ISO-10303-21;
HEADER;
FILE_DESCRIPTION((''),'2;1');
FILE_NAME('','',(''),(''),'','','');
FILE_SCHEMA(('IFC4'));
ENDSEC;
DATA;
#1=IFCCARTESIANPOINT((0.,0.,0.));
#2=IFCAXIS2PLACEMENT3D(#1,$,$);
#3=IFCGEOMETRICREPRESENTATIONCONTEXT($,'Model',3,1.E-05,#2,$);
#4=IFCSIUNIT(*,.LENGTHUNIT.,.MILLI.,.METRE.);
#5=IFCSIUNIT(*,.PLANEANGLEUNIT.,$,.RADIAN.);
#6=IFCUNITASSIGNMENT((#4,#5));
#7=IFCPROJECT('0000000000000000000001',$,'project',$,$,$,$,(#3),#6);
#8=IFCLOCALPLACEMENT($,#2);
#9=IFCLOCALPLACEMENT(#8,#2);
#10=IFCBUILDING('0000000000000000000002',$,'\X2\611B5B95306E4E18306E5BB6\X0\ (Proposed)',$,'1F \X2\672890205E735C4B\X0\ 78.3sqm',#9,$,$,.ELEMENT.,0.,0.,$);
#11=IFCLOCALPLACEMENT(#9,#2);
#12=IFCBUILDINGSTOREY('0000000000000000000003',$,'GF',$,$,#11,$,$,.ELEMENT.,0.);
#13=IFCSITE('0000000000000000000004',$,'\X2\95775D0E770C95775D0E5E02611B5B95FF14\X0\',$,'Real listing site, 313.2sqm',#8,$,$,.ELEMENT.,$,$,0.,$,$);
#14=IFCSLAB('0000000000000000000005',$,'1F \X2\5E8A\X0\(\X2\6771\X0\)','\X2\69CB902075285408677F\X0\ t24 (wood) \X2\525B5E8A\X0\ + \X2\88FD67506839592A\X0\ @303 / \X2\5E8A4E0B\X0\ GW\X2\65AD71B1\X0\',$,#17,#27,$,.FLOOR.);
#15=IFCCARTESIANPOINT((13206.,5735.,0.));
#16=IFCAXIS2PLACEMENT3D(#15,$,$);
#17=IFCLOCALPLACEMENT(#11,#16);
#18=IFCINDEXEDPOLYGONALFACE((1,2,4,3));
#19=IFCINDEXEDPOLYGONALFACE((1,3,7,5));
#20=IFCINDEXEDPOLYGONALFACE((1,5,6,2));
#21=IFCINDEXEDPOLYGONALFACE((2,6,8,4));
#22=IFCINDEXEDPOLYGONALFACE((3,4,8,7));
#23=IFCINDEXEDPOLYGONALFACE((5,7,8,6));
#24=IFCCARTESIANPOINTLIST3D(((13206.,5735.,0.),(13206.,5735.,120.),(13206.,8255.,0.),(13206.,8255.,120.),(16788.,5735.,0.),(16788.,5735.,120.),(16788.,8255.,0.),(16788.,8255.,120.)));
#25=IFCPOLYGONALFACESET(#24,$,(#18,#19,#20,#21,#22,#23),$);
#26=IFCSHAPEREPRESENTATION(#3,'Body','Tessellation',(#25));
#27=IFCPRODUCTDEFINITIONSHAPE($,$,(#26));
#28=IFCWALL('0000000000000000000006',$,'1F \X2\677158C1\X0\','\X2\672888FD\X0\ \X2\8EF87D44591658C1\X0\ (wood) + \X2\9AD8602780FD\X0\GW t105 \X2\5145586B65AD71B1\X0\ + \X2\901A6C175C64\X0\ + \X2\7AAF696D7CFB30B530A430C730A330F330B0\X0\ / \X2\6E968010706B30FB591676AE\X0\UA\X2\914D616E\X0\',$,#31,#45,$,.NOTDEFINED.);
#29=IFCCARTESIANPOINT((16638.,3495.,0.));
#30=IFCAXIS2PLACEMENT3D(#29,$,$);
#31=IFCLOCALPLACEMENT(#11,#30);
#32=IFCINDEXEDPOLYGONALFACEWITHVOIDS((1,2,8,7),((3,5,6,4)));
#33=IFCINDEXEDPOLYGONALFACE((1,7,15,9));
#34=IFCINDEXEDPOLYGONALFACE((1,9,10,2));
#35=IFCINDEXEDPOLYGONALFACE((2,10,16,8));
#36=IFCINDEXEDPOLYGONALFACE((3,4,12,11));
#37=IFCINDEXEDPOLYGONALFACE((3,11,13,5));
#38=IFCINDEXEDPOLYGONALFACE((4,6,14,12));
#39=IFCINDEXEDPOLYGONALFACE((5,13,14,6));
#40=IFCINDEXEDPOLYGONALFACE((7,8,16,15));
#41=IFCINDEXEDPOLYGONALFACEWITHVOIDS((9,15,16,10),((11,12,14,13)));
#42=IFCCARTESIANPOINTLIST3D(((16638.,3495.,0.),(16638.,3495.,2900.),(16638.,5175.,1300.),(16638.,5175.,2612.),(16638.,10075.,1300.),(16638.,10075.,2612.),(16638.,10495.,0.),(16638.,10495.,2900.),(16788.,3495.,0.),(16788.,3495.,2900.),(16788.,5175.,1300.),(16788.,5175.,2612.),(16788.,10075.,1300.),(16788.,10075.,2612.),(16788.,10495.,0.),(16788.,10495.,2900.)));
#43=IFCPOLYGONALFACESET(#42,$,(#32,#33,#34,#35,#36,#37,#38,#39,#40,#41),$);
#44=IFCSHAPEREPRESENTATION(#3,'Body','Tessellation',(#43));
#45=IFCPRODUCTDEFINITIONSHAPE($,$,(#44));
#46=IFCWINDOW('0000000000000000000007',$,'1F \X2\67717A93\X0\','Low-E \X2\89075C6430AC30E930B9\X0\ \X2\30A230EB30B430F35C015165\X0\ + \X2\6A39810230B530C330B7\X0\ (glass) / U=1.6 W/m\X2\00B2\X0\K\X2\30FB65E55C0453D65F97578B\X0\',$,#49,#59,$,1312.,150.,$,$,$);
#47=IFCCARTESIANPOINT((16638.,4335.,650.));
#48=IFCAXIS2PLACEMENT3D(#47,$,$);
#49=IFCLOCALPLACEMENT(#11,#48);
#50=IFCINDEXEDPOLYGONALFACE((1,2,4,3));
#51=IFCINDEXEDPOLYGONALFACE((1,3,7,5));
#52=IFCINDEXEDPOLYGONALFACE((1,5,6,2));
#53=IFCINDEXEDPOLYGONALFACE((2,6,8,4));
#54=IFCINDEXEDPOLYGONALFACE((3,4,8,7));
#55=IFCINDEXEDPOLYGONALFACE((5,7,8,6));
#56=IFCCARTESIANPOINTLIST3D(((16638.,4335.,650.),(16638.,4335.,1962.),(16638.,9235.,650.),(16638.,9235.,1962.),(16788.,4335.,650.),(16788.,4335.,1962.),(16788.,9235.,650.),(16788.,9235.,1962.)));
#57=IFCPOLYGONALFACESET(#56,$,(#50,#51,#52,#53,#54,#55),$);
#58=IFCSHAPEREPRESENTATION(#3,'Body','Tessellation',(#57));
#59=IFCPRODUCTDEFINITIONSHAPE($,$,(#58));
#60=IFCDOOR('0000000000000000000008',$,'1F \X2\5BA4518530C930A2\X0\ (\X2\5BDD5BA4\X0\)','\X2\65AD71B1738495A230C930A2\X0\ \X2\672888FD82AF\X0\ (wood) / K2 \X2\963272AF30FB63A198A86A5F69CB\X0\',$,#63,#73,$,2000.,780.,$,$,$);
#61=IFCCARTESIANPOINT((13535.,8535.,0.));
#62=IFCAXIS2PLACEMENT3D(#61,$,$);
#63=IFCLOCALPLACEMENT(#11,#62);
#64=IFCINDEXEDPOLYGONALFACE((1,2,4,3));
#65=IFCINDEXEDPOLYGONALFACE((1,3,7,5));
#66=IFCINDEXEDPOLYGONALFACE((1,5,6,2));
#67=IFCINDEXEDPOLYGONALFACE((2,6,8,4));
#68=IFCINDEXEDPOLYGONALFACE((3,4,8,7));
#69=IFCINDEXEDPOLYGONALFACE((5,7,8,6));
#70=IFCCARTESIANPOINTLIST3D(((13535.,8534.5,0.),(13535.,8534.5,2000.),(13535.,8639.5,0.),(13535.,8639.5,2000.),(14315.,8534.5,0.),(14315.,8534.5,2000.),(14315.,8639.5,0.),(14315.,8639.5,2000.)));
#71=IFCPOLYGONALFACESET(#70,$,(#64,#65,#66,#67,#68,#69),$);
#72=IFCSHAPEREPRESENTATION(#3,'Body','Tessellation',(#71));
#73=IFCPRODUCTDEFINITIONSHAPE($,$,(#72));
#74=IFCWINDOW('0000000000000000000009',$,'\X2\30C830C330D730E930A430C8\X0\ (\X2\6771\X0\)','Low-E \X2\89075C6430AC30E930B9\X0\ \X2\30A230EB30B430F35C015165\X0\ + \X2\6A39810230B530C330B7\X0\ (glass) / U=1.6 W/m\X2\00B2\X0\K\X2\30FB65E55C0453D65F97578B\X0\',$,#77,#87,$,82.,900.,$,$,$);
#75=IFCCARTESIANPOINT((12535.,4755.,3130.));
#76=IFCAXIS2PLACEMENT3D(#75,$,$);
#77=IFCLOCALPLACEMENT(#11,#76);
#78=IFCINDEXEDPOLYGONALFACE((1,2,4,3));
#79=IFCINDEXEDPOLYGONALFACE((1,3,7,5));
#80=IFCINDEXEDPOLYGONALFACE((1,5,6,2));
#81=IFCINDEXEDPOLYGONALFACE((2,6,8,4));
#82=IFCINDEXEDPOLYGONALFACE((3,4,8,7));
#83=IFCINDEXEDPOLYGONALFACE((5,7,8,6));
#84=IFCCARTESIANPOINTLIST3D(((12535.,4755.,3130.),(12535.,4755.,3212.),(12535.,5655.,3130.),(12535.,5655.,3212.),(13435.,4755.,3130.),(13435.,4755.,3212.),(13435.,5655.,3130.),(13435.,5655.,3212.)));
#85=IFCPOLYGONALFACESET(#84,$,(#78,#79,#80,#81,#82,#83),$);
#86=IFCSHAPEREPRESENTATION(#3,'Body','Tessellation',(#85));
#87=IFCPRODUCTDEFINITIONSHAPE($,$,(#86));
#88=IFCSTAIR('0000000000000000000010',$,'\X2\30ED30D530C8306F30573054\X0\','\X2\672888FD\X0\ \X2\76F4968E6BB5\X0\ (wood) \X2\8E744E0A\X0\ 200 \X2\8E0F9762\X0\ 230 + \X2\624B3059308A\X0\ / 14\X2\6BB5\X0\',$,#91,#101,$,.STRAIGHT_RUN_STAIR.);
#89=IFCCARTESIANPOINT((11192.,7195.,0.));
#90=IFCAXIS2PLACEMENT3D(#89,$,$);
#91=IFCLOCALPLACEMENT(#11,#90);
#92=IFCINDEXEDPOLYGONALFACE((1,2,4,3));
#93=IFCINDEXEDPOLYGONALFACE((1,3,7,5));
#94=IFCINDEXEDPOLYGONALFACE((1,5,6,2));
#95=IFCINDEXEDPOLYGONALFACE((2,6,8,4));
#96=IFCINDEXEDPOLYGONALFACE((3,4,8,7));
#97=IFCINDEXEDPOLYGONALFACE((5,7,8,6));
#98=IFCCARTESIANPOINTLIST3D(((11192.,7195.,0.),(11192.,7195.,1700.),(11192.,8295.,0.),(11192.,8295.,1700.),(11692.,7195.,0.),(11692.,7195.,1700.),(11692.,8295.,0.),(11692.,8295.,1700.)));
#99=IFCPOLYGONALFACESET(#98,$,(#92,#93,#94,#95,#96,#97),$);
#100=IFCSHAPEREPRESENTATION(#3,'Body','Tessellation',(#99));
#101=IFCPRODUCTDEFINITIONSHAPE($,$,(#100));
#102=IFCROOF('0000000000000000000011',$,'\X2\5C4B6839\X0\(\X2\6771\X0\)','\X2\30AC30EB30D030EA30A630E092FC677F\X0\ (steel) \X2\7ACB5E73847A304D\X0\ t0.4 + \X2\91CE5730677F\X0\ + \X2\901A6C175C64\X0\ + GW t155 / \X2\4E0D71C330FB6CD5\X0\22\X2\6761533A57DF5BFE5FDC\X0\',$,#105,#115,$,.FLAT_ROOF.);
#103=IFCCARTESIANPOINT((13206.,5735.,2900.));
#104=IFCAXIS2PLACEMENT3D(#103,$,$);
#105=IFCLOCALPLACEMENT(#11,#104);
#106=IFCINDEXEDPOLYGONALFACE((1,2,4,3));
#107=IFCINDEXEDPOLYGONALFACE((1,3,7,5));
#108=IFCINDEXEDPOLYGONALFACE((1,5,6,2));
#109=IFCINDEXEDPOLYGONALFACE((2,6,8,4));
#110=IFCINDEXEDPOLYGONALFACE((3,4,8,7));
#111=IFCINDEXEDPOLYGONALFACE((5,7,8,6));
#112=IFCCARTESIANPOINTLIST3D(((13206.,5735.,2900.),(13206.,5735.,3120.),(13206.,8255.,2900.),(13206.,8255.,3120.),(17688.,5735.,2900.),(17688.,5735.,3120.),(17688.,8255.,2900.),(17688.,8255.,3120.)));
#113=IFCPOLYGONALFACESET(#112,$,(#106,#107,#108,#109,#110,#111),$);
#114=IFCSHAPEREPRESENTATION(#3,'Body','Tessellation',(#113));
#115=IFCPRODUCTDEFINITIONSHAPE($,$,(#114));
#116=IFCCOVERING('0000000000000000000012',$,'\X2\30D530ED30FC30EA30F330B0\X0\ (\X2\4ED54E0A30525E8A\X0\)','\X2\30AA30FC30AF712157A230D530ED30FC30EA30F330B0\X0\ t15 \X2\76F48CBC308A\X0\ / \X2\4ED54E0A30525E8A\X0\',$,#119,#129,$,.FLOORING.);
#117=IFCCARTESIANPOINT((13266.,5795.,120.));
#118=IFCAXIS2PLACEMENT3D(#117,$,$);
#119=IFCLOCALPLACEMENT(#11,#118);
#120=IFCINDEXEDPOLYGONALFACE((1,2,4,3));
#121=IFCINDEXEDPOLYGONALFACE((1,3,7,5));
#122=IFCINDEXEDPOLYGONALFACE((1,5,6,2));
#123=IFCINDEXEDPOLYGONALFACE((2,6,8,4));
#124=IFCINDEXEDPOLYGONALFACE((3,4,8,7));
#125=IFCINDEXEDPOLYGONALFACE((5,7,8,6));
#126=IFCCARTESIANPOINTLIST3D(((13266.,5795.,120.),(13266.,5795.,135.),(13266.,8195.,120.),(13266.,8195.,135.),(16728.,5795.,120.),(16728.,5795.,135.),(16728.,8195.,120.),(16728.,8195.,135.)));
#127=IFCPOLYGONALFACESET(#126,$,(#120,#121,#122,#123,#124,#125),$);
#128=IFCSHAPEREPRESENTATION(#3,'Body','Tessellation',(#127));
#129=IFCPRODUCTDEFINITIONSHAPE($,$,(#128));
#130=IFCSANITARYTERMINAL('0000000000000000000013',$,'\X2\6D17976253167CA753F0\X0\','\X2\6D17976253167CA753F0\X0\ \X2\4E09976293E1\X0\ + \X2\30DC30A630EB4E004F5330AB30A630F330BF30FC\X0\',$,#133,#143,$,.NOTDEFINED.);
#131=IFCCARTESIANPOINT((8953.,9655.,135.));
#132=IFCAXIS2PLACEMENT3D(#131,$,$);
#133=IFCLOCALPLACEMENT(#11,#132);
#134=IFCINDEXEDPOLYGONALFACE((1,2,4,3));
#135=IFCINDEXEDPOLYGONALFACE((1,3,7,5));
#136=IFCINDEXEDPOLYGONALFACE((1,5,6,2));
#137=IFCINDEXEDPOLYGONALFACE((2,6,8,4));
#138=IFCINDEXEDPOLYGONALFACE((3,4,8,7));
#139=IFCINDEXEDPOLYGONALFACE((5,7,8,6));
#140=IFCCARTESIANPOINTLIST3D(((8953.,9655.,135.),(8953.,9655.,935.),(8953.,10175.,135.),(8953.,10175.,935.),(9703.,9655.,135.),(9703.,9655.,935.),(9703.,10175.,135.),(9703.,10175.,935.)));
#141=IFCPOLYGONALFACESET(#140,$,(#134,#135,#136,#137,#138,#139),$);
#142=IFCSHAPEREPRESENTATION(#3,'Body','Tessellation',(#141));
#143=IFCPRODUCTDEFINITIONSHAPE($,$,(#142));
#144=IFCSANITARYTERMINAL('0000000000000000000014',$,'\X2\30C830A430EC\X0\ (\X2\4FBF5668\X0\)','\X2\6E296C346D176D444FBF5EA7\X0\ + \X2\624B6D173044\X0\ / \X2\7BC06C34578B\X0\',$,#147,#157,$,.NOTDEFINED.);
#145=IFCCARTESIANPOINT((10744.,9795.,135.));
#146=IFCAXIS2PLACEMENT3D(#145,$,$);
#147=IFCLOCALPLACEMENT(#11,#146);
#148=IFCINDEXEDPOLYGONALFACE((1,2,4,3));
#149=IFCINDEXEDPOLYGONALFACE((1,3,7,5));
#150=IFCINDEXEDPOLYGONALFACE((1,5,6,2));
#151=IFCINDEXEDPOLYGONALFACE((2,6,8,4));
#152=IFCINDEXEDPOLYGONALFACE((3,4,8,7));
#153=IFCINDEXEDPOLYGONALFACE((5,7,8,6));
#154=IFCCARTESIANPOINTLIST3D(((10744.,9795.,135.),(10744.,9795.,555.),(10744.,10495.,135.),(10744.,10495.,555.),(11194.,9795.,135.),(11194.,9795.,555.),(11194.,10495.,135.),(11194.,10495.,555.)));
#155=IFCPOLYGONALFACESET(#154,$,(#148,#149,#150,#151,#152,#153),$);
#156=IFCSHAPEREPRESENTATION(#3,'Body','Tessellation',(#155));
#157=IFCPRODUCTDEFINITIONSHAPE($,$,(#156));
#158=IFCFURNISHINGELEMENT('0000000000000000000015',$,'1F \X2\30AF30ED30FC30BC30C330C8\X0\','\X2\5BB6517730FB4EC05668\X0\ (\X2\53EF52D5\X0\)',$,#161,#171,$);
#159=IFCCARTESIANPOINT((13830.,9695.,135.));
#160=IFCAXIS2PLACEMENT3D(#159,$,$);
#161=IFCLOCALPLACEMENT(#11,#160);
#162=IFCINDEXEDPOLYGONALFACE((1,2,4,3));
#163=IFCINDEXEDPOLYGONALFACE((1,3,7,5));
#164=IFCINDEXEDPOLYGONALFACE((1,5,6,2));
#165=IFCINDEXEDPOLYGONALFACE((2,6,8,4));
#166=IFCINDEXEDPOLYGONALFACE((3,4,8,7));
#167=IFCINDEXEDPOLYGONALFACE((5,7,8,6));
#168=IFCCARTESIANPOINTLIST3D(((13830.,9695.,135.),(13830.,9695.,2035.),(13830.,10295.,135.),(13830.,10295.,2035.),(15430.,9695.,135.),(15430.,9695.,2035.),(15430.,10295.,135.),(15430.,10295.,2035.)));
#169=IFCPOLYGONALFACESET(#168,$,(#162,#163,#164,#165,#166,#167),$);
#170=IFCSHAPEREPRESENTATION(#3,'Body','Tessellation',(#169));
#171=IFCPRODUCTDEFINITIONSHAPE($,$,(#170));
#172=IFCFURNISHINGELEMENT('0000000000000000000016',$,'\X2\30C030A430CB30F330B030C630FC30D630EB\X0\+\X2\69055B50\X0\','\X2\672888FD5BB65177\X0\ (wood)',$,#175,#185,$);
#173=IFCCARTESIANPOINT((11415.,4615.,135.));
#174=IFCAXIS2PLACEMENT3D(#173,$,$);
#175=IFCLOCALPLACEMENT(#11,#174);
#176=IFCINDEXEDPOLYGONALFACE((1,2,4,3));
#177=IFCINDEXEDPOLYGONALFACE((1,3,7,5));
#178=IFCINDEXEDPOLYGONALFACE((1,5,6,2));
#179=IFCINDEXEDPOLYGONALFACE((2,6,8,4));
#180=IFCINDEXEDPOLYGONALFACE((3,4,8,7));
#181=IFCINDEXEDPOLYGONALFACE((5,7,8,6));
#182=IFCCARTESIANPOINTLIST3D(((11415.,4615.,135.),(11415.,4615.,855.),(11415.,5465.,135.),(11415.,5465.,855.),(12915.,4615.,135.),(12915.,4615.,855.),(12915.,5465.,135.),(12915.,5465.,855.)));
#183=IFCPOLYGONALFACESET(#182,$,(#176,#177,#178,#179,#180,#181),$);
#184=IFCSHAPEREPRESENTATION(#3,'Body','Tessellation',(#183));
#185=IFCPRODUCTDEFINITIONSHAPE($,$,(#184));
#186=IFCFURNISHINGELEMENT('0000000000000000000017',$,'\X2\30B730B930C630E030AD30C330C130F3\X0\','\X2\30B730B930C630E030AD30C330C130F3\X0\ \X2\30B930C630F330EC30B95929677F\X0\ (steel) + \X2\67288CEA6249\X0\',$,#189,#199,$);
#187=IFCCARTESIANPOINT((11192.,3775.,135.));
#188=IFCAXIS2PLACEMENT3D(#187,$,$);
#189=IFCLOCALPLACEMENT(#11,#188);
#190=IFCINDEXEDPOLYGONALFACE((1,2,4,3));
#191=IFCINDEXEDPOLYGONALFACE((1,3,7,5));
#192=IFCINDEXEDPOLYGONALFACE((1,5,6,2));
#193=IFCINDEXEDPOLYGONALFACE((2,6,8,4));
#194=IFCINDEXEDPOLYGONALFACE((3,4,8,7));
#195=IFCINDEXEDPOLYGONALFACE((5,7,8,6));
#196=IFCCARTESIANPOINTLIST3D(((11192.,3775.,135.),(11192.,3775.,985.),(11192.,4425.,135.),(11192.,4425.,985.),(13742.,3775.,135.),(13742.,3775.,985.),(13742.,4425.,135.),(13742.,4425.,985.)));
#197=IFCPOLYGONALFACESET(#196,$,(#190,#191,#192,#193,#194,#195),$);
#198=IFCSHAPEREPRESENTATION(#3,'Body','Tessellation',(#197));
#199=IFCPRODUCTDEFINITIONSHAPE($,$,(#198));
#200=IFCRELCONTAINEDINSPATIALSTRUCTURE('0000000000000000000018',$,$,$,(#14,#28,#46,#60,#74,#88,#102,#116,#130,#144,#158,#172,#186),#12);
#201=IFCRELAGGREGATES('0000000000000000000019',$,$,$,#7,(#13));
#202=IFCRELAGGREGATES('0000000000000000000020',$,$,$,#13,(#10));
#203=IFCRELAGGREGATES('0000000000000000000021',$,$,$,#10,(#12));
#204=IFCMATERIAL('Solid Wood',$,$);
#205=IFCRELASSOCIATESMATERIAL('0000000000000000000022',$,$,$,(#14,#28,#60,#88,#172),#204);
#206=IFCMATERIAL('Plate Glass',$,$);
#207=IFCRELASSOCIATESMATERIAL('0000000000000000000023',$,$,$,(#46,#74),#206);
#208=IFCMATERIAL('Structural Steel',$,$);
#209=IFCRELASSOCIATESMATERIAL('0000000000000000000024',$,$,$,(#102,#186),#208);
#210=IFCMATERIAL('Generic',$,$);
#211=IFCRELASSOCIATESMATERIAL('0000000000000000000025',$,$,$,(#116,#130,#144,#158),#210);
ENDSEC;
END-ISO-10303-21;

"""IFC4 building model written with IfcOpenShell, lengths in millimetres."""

from ifc_helpers import new_model, si_unit, frame, frame_2d, origin, place, context, project, spatial, rectangle, extrude, material, element, fill, save


model = new_model("IFC4")

# Units and contexts
model_context = context("Model", 3, precision=1e-05, world=origin())
ifc_project = project(units=[si_unit("LENGTHUNIT", "METRE", prefix="MILLI"), si_unit("PLANEANGLEUNIT", "RADIAN")], contexts=[model_context])

# Site, building, storey
site_placement = place(None, origin())
site = spatial("IfcSite", under=ifc_project, at=site_placement, Name="長崎県長崎市愛宕４", ObjectType="Real listing site, 313.2sqm", CompositionType="ELEMENT", RefElevation=0.0)
building_placement = place(site_placement, origin())
building = spatial("IfcBuilding", under=site, at=building_placement, Name="愛宕の丘の家 (Proposed)", ObjectType="1F 木造平屋 78.3sqm", CompositionType="ELEMENT", ElevationOfRefHeight=0.0, ElevationOfTerrain=0.0)
storey_placement = place(building_placement, origin())
storey = spatial("IfcBuildingStorey", under=building, at=storey_placement, Name="GF", CompositionType="ELEMENT", Elevation=0.0)

# Slab
ifc_material_1 = material(Name="Solid Wood")
slab_1_placement = place(storey_placement, frame((13206.0, 5735.0, 0.0)))
element("IfcSlab", 1, at=slab_1_placement, inside=storey, material=ifc_material_1, Name="1F 床(東)", Description="構造用合板 t24 (wood) 剛床 + 製材根太 @303 / 床下 GW断熱", PredefinedType="FLOOR", context=model_context, shape_type="SweptSolid", body=[
    extrude(rectangle(XDim=3582.0, YDim=2520.0, at=frame_2d((1791.0, 1260.0))), frame((13206.0, 5735.0, 0.0)), (0.0, 0.0, 1.0), 120.0),
])

# Wall, opening, window
wall_1_placement = place(storey_placement, frame((16638.0, 3495.0, 0.0)))
wall_1 = element("IfcWall", 2, at=wall_1_placement, inside=storey, material=ifc_material_1, Name="1F 東壁", Description="木製 軸組外壁 (wood) + 高性能GW t105 充填断熱 + 通気層 + 窯業系サイディング / 準耐火・外皮UA配慮", PredefinedType="NOTDEFINED", context=model_context, shape_type="SweptSolid", body=[
    extrude(rectangle(XDim=150.0, YDim=7000.0, at=frame_2d((75.0, 3500.0))), frame((16638.0, 3495.0, 0.0)), (0.0, 0.0, 1.0), 2900.0),
])
opening_1_placement = place(storey_placement, frame((16638.0, 4335.0, 650.0)))
opening_1 = element("IfcOpeningElement", 3, at=opening_1_placement, cuts=wall_1, PredefinedType="NOTDEFINED", context=model_context, shape_type="SweptSolid", body=[
    extrude(rectangle(XDim=150.0, YDim=4900.0, at=frame_2d((75.0, 2450.0))), frame((16638.0, 4335.0, 650.0)), (0.0, 0.0, 1.0), 1312.0),
])
ifc_material_2 = material(Name="Plate Glass")
window_1_placement = place(storey_placement, frame((16638.0, 4335.0, 650.0)))
window_1 = element("IfcWindow", 4, at=window_1_placement, inside=storey, material=ifc_material_2, Name="1F 東窓", Description="Low-E 複層ガラス アルゴン封入 + 樹脂サッシ (glass) / U=1.6 W/m²K・日射取得型", OverallHeight=1312.0, OverallWidth=150.0, context=model_context, shape_type="SweptSolid", body=[
    extrude(rectangle(XDim=150.0, YDim=4900.0, at=frame_2d((75.0, 2450.0))), frame((16638.0, 4335.0, 650.0)), (0.0, 0.0, 1.0), 1312.0),
])
fill(opening_1, window_1)

# Door
door_placement = place(storey_placement, frame((13535.0, 8535.0, 0.0)))
element("IfcDoor", 5, at=door_placement, inside=storey, material=ifc_material_1, Name="1F 室内ドア (寝室)", Description="断熱玄関ドア 木製芯 (wood) / K2 防犯・採風機構", OverallHeight=2000.0, OverallWidth=780.0, context=model_context, shape_type="SweptSolid", body=[
    extrude(rectangle(XDim=780.0, YDim=105.0, at=frame_2d((390.0, 52.0))), frame((13535.0, 8535.0, 0.0)), (0.0, 0.0, 1.0), 2000.0),
])

# Window
window_2_placement = place(storey_placement, frame((12535.0, 4755.0, 3130.0)))
element("IfcWindow", 6, at=window_2_placement, inside=storey, material=ifc_material_2, Name="トップライト (東)", Description="Low-E 複層ガラス アルゴン封入 + 樹脂サッシ (glass) / U=1.6 W/m²K・日射取得型", OverallHeight=82.0, OverallWidth=900.0, context=model_context, shape_type="SweptSolid", body=[
    extrude(rectangle(XDim=900.0, YDim=900.0, at=frame_2d((450.0, 450.0))), frame((12535.0, 4755.0, 3130.0)), (0.0, 0.0, 1.0), 82.0),
])

# Stair
stair_placement = place(storey_placement, frame((11192.0, 7195.0, 0.0)))
element("IfcStair", 7, at=stair_placement, inside=storey, material=ifc_material_1, Name="ロフトはしご", Description="木製 直階段 (wood) 蹴上 200 踏面 230 + 手すり / 14段", PredefinedType="STRAIGHT_RUN_STAIR", context=model_context, shape_type="SweptSolid", body=[
    extrude(rectangle(XDim=500.0, YDim=1100.0, at=frame_2d((250.0, 550.0))), frame((11192.0, 7195.0, 0.0)), (0.0, 0.0, 1.0), 1700.0),
])

# Roof
ifc_material_3 = material(Name="Structural Steel")
roof_placement = place(storey_placement, frame((13206.0, 5735.0, 2900.0)))
element("IfcRoof", 8, at=roof_placement, inside=storey, material=ifc_material_3, Name="屋根(東)", Description="ガルバリウム鋼板 (steel) 立平葺き t0.4 + 野地板 + 通気層 + GW t155 / 不燃・法22条区域対応", PredefinedType="FLAT_ROOF", context=model_context, shape_type="SweptSolid", body=[
    extrude(rectangle(XDim=4482.0, YDim=2520.0, at=frame_2d((2241.0, 1260.0))), frame((13206.0, 5735.0, 2900.0)), (0.0, 0.0, 1.0), 220.0),
])

# Covering
ifc_material_4 = material(Name="Generic")
covering_placement = place(storey_placement, frame((13266.0, 5795.0, 120.0)))
element("IfcCovering", 9, at=covering_placement, inside=storey, material=ifc_material_4, Name="フローリング (仕上げ床)", Description="オーク無垢フローリング t15 直貼り / 仕上げ床", PredefinedType="FLOORING", context=model_context, shape_type="SweptSolid", body=[
    extrude(rectangle(XDim=3462.0, YDim=2400.0, at=frame_2d((1731.0, 1200.0))), frame((13266.0, 5795.0, 120.0)), (0.0, 0.0, 1.0), 15.0),
])

# Sanitary terminals
sanitary_terminal_1_placement = place(storey_placement, frame((8953.0, 9655.0, 135.0)))
element("IfcSanitaryTerminal", 10, at=sanitary_terminal_1_placement, inside=storey, material=ifc_material_4, Name="洗面化粧台", Description="洗面化粧台 三面鏡 + ボウル一体カウンター", PredefinedType="NOTDEFINED", context=model_context, shape_type="SweptSolid", body=[
    extrude(rectangle(XDim=750.0, YDim=520.0, at=frame_2d((375.0, 260.0))), frame((8953.0, 9655.0, 135.0)), (0.0, 0.0, 1.0), 800.0),
])
sanitary_terminal_2_placement = place(storey_placement, frame((10744.0, 9795.0, 135.0)))
element("IfcSanitaryTerminal", 11, at=sanitary_terminal_2_placement, inside=storey, material=ifc_material_4, Name="トイレ (便器)", Description="温水洗浄便座 + 手洗い / 節水型", PredefinedType="NOTDEFINED", context=model_context, shape_type="SweptSolid", body=[
    extrude(rectangle(XDim=450.0, YDim=700.0, at=frame_2d((225.0, 350.0))), frame((10744.0, 9795.0, 135.0)), (0.0, 0.0, 1.0), 420.0),
])

# Furnishing elements
furnishing_1_placement = place(storey_placement, frame((13830.0, 9695.0, 135.0)))
element("IfcFurnishingElement", 12, at=furnishing_1_placement, inside=storey, material=ifc_material_4, Name="1F クローゼット", Description="家具・什器 (可動)", context=model_context, shape_type="SweptSolid", body=[
    extrude(rectangle(XDim=1600.0, YDim=600.0, at=frame_2d((800.0, 300.0))), frame((13830.0, 9695.0, 135.0)), (0.0, 0.0, 1.0), 1900.0),
])
furnishing_2_placement = place(storey_placement, frame((11415.0, 4615.0, 135.0)))
element("IfcFurnishingElement", 13, at=furnishing_2_placement, inside=storey, material=ifc_material_1, Name="ダイニングテーブル+椅子", Description="木製家具 (wood)", context=model_context, shape_type="SweptSolid", body=[
    extrude(rectangle(XDim=1500.0, YDim=850.0, at=frame_2d((750.0, 425.0))), frame((11415.0, 4615.0, 135.0)), (0.0, 0.0, 1.0), 720.0),
])
furnishing_3_placement = place(storey_placement, frame((11192.0, 3775.0, 135.0)))
element("IfcFurnishingElement", 14, at=furnishing_3_placement, inside=storey, material=ifc_material_3, Name="システムキッチン", Description="システムキッチン ステンレス天板 (steel) + 木質扉", context=model_context, shape_type="SweptSolid", body=[
    extrude(rectangle(XDim=2550.0, YDim=650.0, at=frame_2d((1275.0, 325.0))), frame((11192.0, 3775.0, 135.0)), (0.0, 0.0, 1.0), 850.0),
])

save(model, "model.ifc")
